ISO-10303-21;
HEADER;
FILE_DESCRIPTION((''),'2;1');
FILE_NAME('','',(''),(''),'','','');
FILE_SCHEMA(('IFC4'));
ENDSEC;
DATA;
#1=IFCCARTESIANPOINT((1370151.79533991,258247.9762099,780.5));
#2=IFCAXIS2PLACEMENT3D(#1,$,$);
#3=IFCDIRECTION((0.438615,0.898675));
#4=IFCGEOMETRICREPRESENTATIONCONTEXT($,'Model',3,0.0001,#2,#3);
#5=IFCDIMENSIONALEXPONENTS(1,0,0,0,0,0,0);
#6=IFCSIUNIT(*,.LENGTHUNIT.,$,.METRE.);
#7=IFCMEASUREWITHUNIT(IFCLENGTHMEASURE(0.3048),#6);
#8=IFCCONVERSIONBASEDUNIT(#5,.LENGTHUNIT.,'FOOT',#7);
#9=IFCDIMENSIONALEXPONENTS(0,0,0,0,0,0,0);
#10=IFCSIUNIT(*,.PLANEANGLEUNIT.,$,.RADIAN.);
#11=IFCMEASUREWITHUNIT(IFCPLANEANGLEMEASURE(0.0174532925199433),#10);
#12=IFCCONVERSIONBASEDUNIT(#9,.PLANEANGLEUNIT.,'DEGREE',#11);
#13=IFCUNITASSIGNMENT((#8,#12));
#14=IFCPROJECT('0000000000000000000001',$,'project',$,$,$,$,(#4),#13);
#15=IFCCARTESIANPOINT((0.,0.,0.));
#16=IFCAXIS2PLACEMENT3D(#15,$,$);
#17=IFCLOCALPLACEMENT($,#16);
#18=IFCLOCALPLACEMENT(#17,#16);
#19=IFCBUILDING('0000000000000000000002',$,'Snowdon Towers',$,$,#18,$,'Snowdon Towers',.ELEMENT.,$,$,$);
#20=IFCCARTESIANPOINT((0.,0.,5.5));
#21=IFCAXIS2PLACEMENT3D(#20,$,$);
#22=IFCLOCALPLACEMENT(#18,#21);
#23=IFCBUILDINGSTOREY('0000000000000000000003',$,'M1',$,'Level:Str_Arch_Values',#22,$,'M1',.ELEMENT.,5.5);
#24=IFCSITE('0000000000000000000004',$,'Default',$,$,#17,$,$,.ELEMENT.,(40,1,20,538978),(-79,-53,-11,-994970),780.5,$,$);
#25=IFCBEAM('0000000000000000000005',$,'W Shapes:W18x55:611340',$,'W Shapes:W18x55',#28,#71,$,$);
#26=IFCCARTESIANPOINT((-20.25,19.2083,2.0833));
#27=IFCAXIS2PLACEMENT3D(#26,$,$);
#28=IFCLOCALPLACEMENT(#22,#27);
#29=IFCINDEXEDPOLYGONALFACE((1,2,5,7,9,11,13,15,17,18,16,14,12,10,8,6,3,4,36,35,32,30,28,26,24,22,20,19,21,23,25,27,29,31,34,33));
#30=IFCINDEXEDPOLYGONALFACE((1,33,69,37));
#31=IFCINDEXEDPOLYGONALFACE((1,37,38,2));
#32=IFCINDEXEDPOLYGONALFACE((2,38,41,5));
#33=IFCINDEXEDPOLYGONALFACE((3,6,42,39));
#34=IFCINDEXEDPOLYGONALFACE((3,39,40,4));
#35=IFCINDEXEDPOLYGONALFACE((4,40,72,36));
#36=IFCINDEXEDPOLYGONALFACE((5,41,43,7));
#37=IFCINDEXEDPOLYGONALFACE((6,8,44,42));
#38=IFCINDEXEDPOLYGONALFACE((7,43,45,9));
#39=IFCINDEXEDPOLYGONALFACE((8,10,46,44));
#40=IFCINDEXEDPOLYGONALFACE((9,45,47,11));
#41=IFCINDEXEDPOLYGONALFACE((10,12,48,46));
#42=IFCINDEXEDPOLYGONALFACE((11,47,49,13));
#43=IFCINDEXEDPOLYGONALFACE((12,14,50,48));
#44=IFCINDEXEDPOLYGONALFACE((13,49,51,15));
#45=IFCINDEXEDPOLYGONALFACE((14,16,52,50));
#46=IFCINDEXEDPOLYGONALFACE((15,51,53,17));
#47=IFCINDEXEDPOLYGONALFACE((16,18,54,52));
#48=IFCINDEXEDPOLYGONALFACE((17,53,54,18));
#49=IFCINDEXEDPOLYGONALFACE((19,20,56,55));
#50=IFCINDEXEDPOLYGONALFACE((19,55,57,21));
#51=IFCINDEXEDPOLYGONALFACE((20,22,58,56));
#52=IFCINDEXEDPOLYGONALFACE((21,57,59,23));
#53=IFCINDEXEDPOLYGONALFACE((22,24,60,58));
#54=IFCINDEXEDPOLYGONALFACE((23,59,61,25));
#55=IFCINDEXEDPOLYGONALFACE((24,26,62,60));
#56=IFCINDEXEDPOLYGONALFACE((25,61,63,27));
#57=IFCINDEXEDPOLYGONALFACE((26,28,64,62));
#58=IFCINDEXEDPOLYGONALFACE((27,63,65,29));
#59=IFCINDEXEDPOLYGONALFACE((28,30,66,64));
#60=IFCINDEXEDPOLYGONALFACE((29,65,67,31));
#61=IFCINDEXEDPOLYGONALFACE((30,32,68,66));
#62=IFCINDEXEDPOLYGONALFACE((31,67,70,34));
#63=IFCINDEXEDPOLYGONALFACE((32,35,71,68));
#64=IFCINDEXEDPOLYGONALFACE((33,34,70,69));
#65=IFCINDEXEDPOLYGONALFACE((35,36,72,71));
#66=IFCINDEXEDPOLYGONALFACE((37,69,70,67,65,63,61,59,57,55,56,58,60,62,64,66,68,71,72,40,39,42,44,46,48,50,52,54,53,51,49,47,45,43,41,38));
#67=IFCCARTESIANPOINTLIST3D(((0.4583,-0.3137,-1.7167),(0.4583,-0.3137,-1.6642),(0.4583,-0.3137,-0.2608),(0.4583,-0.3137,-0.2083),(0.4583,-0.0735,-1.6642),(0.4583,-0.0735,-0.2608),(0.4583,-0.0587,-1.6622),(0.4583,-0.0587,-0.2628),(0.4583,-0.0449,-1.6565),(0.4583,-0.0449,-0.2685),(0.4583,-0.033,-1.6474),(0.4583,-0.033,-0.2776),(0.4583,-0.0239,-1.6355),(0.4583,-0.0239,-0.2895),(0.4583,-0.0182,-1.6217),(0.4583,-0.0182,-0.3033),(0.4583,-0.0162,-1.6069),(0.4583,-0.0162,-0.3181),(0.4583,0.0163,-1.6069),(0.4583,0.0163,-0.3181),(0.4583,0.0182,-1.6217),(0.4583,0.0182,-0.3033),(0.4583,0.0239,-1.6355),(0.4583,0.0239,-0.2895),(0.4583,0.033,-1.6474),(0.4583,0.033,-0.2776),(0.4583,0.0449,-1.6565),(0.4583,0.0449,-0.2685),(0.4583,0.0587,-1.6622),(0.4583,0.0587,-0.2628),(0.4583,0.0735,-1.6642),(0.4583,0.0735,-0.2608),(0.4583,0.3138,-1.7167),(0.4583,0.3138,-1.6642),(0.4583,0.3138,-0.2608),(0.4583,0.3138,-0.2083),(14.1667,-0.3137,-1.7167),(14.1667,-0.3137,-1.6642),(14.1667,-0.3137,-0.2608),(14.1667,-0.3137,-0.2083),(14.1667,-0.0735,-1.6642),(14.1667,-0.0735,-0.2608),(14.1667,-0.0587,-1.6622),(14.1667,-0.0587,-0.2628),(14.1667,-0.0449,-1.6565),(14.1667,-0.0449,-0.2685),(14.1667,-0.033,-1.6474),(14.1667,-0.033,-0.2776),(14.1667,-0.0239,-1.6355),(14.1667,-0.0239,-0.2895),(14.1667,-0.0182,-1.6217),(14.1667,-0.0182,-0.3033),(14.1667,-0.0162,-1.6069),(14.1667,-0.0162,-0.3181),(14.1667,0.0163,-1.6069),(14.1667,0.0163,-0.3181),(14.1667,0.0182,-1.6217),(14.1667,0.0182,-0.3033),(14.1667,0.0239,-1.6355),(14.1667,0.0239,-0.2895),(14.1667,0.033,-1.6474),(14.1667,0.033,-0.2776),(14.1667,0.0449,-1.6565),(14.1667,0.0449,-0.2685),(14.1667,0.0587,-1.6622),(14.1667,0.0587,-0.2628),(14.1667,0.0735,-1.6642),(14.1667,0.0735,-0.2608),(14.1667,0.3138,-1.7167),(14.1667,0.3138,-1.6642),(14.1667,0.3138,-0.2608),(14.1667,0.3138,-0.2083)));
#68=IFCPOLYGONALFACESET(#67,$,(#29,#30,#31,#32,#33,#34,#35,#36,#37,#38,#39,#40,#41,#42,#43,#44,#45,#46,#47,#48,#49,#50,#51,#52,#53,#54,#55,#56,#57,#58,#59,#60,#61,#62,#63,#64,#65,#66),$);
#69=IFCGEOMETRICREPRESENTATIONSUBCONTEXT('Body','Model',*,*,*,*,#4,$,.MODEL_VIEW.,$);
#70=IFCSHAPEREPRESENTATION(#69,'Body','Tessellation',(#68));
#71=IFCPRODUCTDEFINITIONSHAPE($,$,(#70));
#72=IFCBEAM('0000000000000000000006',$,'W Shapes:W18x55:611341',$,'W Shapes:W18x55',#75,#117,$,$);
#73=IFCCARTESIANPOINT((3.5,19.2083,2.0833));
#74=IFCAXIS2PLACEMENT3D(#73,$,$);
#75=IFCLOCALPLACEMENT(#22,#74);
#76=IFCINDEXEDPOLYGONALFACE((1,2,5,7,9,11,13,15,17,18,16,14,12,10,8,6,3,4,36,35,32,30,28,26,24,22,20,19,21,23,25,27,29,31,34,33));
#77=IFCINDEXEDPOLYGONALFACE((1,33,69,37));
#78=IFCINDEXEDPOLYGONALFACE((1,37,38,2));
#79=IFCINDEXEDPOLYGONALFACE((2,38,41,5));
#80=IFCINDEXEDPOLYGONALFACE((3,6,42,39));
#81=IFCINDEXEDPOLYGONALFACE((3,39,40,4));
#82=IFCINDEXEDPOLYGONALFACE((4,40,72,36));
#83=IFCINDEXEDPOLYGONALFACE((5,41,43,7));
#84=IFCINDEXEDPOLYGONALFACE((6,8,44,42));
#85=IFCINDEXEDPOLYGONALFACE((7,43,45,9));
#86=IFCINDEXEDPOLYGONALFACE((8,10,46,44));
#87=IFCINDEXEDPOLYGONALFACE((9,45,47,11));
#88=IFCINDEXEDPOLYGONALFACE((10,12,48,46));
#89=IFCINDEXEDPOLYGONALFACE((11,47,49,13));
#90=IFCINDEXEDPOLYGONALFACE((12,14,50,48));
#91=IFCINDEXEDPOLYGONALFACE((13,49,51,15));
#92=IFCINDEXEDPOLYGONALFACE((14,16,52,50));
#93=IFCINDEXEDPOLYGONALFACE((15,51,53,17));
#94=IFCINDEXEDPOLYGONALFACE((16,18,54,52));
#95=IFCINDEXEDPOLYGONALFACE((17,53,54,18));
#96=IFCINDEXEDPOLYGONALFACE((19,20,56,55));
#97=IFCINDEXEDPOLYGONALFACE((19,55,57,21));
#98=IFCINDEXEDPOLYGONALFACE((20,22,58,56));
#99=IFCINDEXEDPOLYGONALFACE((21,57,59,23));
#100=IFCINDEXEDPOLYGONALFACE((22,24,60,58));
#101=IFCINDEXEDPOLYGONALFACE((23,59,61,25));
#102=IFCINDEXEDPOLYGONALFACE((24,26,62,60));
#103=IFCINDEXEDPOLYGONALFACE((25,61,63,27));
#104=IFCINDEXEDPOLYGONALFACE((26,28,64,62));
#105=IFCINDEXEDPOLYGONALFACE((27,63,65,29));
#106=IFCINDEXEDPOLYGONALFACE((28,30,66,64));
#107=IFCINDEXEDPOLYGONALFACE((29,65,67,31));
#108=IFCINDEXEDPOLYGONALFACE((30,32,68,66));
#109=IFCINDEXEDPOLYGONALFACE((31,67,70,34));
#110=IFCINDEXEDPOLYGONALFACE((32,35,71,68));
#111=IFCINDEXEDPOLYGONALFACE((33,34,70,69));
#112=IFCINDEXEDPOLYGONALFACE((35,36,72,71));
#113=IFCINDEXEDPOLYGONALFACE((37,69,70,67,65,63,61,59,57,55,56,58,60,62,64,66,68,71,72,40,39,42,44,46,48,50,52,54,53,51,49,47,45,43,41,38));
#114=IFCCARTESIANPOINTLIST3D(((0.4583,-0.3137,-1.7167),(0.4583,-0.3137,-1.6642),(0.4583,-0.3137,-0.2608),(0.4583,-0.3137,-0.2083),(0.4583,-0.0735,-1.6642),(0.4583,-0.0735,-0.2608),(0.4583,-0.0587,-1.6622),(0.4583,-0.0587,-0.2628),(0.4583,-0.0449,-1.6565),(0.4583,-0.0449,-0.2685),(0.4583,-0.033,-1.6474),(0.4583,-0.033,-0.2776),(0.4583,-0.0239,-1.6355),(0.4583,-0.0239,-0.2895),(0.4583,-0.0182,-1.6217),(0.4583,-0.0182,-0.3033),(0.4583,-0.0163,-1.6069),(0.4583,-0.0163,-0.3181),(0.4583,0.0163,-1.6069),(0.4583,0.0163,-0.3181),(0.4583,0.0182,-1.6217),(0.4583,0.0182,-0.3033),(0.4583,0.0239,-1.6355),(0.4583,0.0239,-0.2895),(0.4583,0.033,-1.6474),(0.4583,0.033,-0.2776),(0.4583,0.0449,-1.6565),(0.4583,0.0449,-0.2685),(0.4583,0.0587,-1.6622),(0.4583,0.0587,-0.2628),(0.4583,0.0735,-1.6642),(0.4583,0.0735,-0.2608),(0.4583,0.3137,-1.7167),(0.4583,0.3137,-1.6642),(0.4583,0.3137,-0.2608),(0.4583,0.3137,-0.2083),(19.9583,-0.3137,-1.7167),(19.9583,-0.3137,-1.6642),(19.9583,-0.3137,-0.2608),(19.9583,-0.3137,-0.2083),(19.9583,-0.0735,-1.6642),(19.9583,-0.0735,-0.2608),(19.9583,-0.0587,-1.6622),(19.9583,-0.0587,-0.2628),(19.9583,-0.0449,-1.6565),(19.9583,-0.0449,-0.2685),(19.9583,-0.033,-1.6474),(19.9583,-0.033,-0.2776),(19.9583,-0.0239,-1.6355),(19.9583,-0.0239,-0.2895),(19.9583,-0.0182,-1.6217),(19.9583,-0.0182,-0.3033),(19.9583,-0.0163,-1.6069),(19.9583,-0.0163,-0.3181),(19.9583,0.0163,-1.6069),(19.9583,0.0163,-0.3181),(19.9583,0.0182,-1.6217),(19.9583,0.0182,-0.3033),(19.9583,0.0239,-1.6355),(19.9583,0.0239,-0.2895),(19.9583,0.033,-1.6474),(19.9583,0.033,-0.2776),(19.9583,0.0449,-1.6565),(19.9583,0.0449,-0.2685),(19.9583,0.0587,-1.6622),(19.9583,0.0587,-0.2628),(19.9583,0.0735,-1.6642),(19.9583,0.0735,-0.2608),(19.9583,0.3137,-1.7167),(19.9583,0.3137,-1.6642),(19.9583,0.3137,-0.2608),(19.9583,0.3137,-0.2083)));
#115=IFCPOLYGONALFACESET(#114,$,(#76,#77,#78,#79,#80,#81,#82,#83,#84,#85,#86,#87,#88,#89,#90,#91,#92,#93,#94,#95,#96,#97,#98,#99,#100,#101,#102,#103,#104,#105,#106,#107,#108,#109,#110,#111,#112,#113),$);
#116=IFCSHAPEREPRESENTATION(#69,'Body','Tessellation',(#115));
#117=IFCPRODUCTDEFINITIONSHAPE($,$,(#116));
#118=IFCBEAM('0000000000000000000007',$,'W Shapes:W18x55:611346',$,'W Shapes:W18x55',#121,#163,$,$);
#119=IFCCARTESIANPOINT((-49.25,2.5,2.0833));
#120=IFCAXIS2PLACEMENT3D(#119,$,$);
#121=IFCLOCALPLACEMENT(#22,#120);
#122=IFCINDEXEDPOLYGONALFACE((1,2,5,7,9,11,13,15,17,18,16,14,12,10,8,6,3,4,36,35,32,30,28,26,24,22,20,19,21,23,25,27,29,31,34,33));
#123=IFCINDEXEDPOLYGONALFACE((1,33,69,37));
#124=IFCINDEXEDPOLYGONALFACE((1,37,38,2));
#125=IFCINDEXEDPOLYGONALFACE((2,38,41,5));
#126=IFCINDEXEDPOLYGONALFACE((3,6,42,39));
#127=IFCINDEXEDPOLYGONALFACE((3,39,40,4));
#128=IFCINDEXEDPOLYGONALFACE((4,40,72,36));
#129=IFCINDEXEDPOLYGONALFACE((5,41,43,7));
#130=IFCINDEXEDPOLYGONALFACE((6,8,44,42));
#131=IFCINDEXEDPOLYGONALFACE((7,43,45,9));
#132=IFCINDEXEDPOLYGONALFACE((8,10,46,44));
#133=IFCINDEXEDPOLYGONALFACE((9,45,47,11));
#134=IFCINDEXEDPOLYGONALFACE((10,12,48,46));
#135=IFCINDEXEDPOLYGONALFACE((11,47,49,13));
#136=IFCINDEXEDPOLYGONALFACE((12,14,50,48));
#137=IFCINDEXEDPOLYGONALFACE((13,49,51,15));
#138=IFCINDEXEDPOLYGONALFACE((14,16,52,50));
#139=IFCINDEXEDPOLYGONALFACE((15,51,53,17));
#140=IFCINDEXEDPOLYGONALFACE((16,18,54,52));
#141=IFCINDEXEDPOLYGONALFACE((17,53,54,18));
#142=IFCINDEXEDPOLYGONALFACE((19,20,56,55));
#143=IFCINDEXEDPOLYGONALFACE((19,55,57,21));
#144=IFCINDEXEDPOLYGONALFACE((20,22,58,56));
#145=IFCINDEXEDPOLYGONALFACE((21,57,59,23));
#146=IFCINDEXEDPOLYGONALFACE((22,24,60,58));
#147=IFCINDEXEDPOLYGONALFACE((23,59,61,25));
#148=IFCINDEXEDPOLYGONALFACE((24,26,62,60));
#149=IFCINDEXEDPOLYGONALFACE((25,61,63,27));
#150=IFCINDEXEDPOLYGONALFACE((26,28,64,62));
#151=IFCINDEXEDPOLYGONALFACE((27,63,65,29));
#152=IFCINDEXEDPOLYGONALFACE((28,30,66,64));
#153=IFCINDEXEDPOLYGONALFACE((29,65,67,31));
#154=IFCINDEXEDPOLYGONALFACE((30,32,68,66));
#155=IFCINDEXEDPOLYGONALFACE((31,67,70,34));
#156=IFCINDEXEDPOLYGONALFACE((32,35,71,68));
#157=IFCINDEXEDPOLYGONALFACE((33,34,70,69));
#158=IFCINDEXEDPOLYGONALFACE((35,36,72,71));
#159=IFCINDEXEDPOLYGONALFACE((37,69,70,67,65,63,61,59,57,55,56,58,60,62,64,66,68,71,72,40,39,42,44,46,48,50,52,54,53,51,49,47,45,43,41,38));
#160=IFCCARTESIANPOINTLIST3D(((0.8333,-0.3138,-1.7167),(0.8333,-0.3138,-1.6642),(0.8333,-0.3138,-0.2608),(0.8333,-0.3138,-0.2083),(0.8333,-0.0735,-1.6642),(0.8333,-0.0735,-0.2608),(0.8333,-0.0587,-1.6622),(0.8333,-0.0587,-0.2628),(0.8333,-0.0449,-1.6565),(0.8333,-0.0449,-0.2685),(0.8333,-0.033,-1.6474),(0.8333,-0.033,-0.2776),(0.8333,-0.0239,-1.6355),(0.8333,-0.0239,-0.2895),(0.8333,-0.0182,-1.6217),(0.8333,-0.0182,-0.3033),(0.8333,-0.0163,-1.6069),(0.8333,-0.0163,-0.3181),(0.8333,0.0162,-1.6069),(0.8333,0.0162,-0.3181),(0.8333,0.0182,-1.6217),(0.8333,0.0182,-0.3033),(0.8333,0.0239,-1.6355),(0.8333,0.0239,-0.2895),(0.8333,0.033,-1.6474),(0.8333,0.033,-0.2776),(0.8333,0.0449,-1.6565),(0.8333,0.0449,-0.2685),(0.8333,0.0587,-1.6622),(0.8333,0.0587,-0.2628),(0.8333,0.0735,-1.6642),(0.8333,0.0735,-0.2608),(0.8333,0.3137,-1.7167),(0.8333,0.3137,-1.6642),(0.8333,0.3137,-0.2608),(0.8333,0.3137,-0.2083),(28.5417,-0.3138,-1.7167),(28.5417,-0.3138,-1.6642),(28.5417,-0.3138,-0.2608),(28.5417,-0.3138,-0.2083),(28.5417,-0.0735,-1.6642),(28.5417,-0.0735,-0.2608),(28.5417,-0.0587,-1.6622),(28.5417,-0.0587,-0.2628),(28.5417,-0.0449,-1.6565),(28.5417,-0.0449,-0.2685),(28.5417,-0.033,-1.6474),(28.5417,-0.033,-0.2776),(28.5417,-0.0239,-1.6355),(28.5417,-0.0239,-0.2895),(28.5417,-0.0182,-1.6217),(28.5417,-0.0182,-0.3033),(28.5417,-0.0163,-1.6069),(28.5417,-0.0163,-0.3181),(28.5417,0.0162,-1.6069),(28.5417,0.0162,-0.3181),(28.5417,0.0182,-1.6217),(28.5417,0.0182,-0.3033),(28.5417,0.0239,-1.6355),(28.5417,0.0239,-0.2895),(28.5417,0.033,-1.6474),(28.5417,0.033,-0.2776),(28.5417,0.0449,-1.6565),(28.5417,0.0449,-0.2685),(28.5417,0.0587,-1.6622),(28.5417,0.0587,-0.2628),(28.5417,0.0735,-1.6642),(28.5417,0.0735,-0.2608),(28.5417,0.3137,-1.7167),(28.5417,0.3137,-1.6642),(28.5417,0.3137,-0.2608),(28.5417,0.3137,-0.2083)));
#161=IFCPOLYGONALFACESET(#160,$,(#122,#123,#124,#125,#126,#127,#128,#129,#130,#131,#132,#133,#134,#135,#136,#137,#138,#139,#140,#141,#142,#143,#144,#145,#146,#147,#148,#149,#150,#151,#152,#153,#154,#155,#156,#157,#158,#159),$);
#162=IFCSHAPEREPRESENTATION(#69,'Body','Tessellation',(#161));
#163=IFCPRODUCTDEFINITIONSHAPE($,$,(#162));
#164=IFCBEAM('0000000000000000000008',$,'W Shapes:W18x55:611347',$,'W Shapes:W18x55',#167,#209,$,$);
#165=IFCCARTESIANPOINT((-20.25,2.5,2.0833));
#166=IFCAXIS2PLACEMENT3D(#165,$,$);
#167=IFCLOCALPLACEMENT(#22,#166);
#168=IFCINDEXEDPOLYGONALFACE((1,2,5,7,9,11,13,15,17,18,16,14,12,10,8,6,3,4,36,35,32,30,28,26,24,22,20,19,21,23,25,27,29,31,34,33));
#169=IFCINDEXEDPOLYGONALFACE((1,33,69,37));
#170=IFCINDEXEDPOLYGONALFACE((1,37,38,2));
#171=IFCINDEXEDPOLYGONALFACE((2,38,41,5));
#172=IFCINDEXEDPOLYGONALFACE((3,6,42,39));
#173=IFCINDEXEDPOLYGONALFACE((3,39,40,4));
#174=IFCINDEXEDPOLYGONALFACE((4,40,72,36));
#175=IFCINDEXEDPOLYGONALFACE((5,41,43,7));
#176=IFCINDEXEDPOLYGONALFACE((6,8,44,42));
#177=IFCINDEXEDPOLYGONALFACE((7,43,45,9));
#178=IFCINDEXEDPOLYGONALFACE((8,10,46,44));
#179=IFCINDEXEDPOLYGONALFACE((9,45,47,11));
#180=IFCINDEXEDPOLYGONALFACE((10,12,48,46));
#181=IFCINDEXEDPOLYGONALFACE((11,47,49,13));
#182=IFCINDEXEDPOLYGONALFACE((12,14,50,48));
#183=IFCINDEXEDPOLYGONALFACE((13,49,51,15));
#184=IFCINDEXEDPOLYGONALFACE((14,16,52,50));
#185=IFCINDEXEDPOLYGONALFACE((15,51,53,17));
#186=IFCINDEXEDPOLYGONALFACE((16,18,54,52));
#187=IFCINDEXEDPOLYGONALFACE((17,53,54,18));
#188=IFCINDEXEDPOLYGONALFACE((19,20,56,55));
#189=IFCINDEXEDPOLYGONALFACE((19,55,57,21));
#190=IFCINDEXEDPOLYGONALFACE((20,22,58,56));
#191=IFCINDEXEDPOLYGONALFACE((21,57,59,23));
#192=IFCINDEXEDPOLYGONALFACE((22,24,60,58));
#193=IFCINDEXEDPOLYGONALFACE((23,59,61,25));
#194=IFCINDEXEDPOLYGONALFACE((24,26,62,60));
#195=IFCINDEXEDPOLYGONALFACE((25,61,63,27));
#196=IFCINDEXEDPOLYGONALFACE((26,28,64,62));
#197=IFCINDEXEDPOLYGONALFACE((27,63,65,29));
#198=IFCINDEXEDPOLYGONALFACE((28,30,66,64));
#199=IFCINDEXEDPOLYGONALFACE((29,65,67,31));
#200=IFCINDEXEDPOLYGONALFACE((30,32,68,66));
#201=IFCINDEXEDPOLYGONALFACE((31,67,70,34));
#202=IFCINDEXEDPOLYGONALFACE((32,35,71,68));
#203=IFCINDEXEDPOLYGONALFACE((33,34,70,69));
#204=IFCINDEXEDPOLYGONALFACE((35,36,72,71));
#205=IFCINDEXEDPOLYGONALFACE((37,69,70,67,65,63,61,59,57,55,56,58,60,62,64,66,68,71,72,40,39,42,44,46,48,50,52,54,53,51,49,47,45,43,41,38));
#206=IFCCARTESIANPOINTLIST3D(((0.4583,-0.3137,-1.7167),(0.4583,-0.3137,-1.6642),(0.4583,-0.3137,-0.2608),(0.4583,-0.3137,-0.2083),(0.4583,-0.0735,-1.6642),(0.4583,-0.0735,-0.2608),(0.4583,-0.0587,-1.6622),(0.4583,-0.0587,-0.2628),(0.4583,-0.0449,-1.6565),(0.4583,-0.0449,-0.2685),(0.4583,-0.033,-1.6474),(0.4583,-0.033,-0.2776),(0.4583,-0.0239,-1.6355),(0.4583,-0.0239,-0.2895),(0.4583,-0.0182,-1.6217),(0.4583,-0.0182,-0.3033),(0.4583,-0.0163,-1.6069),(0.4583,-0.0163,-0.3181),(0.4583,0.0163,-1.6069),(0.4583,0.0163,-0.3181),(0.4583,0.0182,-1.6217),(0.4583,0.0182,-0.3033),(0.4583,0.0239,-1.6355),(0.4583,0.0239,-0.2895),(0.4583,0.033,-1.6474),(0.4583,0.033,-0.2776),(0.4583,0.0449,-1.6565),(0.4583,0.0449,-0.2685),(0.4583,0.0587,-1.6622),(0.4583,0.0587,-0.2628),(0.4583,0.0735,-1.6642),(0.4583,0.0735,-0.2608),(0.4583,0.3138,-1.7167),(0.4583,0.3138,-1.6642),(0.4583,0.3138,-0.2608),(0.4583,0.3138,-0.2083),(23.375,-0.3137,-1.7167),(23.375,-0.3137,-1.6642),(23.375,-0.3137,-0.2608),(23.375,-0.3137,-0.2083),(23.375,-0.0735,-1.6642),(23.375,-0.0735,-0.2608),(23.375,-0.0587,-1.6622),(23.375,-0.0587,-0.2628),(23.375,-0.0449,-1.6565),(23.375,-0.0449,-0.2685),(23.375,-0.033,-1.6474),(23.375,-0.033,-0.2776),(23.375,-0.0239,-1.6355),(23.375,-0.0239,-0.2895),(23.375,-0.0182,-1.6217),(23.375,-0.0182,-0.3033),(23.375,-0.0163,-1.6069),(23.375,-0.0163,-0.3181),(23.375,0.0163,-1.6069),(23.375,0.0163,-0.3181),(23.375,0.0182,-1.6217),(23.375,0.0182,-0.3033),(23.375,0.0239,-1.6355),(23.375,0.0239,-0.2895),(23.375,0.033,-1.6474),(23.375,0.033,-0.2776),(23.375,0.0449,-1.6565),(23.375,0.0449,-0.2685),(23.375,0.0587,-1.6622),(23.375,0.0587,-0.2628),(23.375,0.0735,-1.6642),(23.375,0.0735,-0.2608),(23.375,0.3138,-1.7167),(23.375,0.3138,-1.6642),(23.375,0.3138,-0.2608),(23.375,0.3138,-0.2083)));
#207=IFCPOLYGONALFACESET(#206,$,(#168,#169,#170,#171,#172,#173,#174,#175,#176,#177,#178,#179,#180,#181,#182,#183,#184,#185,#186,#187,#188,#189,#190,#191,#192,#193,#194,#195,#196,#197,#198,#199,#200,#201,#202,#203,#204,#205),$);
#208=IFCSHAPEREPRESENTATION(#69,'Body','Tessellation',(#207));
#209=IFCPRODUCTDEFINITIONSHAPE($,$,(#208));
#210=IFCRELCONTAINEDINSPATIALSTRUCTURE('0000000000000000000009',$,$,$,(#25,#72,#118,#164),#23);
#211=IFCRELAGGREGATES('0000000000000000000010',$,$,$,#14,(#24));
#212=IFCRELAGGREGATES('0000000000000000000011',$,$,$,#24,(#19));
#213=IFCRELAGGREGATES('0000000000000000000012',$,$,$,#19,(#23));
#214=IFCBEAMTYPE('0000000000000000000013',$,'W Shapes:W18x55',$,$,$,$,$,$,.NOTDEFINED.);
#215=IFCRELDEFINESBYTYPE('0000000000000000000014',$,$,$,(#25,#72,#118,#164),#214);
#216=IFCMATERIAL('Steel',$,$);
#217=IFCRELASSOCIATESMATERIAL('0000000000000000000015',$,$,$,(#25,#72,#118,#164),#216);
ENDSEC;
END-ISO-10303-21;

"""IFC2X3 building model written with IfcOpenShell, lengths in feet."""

from ifc_helpers import new_model, entity, si_unit, converted_unit, direction, frame, frame_2d, origin, place, context, subcontext, project, spatial, i_section, extrude, material, type_object, element, save


model = new_model("IFC2X3")

# Units and contexts
model_context = context("Model", 3, precision=0.0001, world=frame((1370151.79533991, 258247.9762099, 780.5)), true_north=direction((0.438615, 0.898675)))
body_context = subcontext(model_context, "Body", "Model", "MODEL_VIEW")
ifc_project = project(units=[converted_unit("LENGTHUNIT", "FOOT", entity("IfcLengthMeasure", 0.3048), si_unit("LENGTHUNIT", "METRE"), dimensions=[1, 0, 0, 0, 0, 0, 0]), converted_unit("PLANEANGLEUNIT", "DEGREE", entity("IfcPlaneAngleMeasure", 0.0174532925199433), si_unit("PLANEANGLEUNIT", "RADIAN"), dimensions=[0, 0, 0, 0, 0, 0, 0])], contexts=[model_context])

# Site, building, storey
site_placement = place(None, origin())
site = spatial("IfcSite", under=ifc_project, at=site_placement, Name="Default", CompositionType="ELEMENT", RefLatitude=(40, 1, 20, 538978), RefLongitude=(-79, -53, -11, -994970), RefElevation=780.5)
building_placement = place(site_placement, origin())
building = spatial("IfcBuilding", under=site, at=building_placement, Name="Snowdon Towers", LongName="Snowdon Towers", CompositionType="ELEMENT")
storey_placement = place(building_placement, frame((0.0, 0.0, 5.5)))
storey = spatial("IfcBuildingStorey", under=building, at=storey_placement, Name="M1", ObjectType="Level:Str_Arch_Values", LongName="M1", CompositionType="ELEMENT", Elevation=5.5)

# Beams
ifc_material_1 = material(Name="Steel")
beam_type_1 = type_object("IfcBeamType", Name="W Shapes:W18x55", PredefinedType="NOTDEFINED")
beam_1_placement = place(storey_placement, frame((-20.25, 19.2083, 2.0833)))
element("IfcBeam", 1, at=beam_1_placement, inside=storey, type_object=beam_type_1, material=ifc_material_1, Name="W Shapes:W18x55:611340", ObjectType="W Shapes:W18x55", context=body_context, shape_type="SweptSolid", body=[
    extrude(i_section(OverallWidth=0.6275, OverallDepth=1.5083, WebThickness=0.0325, FlangeThickness=0.0525, FilletRadius=0.0573, at=frame_2d((0.0, 0.0), x_axis=(0.0, 1.0))), frame((0.4583, 0.0, -0.9625), z_axis=(1.0, 0.0, 0.0), x_axis=(0.0, 0.0, -1.0)), (0.0, 0.0, 1.0), 13.7083),
])
beam_2_placement = place(storey_placement, frame((3.5, 19.2083, 2.0833)))
element("IfcBeam", 2, at=beam_2_placement, inside=storey, type_object=beam_type_1, material=ifc_material_1, Name="W Shapes:W18x55:611341", ObjectType="W Shapes:W18x55", context=body_context, shape_type="SweptSolid", body=[
    extrude(i_section(OverallWidth=0.6275, OverallDepth=1.5083, WebThickness=0.0325, FlangeThickness=0.0525, FilletRadius=0.0573, at=frame_2d((0.0, 0.0), x_axis=(0.0, 1.0))), frame((0.4583, 0.0, -0.9625), z_axis=(1.0, 0.0, 0.0), x_axis=(0.0, 0.0, -1.0)), (0.0, 0.0, 1.0), 19.5),
])
beam_3_placement = place(storey_placement, frame((-49.25, 2.5, 2.0833)))
element("IfcBeam", 3, at=beam_3_placement, inside=storey, type_object=beam_type_1, material=ifc_material_1, Name="W Shapes:W18x55:611346", ObjectType="W Shapes:W18x55", context=body_context, shape_type="SweptSolid", body=[
    extrude(i_section(OverallWidth=0.6275, OverallDepth=1.5083, WebThickness=0.0325, FlangeThickness=0.0525, FilletRadius=0.0573, at=frame_2d((0.0, 0.0), x_axis=(0.0, 1.0))), frame((0.8333, 0.0, -0.9625), z_axis=(1.0, 0.0, 0.0), x_axis=(0.0, 0.0, -1.0)), (0.0, 0.0, 1.0), 27.7083),
])
beam_4_placement = place(storey_placement, frame((-20.25, 2.5, 2.0833)))
element("IfcBeam", 4, at=beam_4_placement, inside=storey, type_object=beam_type_1, material=ifc_material_1, Name="W Shapes:W18x55:611347", ObjectType="W Shapes:W18x55", context=body_context, shape_type="SweptSolid", body=[
    extrude(i_section(OverallWidth=0.6275, OverallDepth=1.5083, WebThickness=0.0325, FlangeThickness=0.0525, FilletRadius=0.0573, at=frame_2d((0.0, 0.0), x_axis=(0.0, 1.0))), frame((0.4583, 0.0, -0.9625), z_axis=(1.0, 0.0, 0.0), x_axis=(0.0, 0.0, -1.0)), (0.0, 0.0, 1.0), 22.9167),
])

save(model, "model.ifc")
